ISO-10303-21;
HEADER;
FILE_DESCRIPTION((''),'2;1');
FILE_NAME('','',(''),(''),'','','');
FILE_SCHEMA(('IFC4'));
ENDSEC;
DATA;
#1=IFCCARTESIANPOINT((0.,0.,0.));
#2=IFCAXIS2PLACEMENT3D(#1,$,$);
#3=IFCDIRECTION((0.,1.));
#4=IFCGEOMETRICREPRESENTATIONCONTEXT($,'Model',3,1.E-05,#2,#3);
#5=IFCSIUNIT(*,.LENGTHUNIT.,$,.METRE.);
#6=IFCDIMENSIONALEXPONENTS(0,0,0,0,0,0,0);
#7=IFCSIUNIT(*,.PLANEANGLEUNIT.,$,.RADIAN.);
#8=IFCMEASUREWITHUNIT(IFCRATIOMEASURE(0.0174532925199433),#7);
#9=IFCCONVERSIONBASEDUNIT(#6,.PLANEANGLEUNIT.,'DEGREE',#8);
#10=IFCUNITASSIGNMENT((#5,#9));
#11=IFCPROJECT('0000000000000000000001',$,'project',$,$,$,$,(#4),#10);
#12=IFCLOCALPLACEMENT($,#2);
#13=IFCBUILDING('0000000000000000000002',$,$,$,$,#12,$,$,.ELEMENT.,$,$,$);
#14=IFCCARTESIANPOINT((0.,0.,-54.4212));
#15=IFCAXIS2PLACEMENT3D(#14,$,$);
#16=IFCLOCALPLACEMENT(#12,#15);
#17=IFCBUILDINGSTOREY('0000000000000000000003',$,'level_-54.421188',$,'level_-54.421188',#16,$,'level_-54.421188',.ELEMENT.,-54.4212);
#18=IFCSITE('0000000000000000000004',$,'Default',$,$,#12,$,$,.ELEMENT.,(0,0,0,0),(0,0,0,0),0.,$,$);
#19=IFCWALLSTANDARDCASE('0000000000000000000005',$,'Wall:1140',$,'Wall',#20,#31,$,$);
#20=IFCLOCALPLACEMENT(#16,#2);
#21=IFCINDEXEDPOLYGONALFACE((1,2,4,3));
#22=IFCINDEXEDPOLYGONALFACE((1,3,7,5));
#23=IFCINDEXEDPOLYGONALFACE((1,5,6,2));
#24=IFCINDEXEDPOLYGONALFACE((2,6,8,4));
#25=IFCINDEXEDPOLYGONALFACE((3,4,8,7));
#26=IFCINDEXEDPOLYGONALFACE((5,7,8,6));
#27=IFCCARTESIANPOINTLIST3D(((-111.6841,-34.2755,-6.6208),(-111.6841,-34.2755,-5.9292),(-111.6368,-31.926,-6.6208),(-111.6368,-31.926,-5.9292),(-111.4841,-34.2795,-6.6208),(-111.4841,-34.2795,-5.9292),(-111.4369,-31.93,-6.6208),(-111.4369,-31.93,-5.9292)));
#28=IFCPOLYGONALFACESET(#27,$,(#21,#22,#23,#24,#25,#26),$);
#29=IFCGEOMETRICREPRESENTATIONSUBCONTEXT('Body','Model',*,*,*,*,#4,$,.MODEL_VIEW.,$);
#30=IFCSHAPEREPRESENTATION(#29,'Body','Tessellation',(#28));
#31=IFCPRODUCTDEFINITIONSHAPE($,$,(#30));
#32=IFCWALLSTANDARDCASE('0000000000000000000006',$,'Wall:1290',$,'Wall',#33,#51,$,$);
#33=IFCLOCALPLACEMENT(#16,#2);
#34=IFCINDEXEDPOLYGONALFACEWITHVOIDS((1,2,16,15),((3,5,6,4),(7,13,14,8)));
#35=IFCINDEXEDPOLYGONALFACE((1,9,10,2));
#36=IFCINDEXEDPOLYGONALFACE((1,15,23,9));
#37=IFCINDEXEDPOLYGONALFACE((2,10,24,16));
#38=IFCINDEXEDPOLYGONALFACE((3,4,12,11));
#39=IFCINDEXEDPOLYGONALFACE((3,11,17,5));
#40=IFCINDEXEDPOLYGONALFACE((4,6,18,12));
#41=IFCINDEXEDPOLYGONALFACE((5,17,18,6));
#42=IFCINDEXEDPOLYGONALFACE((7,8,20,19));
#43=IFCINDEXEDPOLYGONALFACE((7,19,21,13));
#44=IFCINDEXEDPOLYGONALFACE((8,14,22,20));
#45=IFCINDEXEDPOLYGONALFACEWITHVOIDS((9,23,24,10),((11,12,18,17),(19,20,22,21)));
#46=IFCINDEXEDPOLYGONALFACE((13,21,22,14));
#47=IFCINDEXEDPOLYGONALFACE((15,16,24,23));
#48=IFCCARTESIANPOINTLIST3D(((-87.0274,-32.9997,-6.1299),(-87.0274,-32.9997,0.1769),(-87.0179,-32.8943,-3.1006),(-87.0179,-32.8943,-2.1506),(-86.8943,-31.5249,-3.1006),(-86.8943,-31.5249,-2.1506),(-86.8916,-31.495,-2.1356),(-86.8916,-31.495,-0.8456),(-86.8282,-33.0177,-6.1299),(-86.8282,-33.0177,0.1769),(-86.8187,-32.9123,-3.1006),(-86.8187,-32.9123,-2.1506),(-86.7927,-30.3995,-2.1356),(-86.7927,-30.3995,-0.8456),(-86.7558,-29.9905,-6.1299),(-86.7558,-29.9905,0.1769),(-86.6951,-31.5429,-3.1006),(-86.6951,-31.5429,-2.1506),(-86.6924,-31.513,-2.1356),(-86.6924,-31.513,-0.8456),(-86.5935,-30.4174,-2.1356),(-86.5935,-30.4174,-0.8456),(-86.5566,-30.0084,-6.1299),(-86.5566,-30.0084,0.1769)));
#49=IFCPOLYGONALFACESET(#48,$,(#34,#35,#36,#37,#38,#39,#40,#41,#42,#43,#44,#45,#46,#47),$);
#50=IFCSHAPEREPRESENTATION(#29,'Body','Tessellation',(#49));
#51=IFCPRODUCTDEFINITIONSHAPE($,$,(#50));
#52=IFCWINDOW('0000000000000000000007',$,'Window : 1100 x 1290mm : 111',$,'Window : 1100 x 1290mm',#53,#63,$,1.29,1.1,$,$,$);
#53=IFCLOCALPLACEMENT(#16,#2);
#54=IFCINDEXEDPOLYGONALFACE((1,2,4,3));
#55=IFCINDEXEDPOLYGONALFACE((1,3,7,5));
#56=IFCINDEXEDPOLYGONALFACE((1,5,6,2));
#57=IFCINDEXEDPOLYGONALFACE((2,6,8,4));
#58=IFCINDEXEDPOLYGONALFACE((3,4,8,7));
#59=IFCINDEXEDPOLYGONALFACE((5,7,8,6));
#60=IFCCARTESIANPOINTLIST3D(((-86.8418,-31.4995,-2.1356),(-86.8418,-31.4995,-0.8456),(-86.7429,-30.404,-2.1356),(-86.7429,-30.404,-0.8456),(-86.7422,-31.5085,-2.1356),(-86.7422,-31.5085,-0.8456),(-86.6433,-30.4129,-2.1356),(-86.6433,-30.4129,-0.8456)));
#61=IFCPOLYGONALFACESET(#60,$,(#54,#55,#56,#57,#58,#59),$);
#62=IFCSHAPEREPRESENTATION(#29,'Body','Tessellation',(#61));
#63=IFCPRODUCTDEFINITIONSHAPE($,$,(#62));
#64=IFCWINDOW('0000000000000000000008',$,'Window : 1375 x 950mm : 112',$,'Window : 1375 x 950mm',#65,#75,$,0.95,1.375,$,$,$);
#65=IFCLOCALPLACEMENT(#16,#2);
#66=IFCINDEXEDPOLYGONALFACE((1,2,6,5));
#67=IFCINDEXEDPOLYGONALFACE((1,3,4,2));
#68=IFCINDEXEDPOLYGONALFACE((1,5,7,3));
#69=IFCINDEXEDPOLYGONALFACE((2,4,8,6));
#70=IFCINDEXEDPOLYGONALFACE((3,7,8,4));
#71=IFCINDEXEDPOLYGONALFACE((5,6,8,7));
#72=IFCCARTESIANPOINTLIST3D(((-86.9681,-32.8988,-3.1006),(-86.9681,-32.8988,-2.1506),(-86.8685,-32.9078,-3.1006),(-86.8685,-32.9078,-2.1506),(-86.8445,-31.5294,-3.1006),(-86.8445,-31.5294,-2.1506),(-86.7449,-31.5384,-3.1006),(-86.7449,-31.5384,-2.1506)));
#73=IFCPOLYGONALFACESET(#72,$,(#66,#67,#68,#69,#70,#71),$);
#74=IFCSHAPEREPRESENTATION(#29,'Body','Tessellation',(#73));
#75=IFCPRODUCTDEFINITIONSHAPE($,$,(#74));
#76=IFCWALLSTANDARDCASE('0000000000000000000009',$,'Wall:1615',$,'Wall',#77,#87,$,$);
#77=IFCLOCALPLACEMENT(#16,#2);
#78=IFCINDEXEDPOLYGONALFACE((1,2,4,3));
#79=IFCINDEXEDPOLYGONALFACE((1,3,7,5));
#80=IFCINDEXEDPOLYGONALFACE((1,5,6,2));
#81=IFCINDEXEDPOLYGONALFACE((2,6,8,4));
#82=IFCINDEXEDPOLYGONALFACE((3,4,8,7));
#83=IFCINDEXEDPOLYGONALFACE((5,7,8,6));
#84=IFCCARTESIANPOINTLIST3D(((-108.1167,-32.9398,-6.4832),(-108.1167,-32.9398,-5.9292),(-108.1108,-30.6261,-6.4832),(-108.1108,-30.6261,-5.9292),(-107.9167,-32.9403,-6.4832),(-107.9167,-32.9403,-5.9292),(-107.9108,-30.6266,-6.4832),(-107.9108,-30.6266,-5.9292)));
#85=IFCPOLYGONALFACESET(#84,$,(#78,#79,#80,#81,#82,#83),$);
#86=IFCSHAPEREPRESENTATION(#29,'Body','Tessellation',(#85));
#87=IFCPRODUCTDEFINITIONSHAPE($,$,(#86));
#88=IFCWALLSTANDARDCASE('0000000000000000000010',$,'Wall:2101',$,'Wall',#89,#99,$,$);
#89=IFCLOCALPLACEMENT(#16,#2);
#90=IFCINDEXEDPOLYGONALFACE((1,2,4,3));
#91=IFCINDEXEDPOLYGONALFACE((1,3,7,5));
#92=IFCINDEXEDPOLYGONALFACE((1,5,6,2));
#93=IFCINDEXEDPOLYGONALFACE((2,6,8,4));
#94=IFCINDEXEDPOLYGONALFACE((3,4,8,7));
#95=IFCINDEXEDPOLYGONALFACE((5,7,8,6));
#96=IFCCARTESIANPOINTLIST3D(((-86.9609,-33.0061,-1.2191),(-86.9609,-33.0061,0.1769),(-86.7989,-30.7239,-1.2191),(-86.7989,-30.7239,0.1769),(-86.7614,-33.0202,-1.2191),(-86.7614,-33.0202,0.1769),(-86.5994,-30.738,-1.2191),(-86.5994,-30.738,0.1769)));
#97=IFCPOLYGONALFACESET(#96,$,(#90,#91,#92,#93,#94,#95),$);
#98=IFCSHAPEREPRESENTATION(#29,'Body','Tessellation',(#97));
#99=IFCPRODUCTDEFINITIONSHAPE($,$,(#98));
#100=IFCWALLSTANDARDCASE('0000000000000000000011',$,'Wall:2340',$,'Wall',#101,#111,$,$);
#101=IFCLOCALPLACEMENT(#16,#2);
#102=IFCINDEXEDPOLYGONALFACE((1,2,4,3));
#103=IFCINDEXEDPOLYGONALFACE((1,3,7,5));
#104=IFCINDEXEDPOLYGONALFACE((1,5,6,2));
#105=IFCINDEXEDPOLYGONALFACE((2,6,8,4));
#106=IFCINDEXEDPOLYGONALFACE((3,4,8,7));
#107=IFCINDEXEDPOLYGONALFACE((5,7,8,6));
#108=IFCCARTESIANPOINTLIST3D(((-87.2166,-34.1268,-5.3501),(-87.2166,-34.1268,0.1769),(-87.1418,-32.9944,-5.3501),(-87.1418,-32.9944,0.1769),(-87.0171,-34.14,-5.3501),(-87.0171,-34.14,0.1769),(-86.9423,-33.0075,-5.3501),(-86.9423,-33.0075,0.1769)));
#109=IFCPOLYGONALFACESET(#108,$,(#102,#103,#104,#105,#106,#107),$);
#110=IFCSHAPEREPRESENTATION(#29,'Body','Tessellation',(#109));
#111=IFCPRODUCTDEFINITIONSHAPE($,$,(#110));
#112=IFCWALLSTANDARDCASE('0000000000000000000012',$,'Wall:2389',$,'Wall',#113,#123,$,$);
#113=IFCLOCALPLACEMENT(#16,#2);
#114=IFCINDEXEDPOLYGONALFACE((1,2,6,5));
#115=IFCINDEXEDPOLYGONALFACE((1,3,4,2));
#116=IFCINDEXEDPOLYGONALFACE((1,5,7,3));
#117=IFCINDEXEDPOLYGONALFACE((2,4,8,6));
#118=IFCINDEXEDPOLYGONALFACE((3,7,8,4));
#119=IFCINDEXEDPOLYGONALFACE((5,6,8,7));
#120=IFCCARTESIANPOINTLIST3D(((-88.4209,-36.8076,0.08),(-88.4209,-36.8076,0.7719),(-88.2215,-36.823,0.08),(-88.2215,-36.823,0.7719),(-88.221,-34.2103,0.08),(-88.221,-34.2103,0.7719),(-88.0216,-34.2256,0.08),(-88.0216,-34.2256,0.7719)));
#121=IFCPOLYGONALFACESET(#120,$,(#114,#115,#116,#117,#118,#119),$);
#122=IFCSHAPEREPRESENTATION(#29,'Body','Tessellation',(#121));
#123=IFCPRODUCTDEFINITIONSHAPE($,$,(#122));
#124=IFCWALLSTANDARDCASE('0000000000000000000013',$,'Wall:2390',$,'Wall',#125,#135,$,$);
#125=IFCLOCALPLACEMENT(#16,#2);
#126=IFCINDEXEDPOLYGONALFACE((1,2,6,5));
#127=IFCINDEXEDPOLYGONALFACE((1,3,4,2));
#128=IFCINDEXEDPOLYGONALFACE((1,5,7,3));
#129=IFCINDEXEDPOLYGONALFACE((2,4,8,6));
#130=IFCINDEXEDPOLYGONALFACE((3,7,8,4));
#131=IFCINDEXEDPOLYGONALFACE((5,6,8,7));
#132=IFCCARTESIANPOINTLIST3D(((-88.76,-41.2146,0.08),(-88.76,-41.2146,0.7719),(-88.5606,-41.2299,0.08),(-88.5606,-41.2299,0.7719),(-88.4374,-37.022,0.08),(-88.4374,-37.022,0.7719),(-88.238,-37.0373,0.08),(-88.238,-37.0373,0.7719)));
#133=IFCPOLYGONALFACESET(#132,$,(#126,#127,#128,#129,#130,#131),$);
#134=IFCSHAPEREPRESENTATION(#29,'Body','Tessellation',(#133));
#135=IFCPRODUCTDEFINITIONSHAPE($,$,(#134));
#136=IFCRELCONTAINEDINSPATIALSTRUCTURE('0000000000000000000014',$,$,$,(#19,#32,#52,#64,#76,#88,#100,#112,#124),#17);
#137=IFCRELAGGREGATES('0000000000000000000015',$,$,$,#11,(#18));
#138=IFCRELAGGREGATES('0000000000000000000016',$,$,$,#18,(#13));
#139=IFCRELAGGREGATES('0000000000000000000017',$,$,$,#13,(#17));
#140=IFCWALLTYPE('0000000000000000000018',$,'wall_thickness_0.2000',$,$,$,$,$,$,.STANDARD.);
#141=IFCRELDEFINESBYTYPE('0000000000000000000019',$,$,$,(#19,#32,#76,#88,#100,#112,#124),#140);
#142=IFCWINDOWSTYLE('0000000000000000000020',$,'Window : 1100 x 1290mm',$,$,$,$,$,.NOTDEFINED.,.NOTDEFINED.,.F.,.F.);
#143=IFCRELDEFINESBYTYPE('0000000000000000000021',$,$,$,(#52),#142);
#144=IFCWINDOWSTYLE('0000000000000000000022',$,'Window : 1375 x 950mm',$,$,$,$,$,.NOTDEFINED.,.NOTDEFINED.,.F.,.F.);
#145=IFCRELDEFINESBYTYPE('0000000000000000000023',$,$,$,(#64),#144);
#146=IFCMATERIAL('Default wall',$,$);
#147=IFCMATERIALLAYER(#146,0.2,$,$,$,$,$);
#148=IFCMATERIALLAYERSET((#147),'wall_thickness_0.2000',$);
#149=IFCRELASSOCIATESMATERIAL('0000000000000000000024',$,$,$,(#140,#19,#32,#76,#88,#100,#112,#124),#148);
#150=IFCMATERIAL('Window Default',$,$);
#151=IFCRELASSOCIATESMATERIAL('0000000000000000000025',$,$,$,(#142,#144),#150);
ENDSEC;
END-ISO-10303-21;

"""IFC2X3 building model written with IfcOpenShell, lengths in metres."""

from ifc_helpers import new_model, entity, si_unit, converted_unit, direction, frame, frame_2d, origin, origin_2d_with_axis, place, context, subcontext, project, spatial, polyline, rectangle, outline, extrude, source, transform, mapped, material, layer, layer_set, layer_usage, type_object, type_shapes, element, fill, save


model = new_model("IFC2X3")

# Units and contexts
model_context = context("Model", 3, precision=1e-05, world=origin(), true_north=direction((0.0, 1.0)))
body_context = subcontext(model_context, "Body", "Model", "MODEL_VIEW")
ifc_project = project(units=[si_unit("LENGTHUNIT", "METRE"), converted_unit("PLANEANGLEUNIT", "DEGREE", entity("IfcRatioMeasure", 0.0174532925199433), si_unit("PLANEANGLEUNIT", "RADIAN"), dimensions=[0, 0, 0, 0, 0, 0, 0])], contexts=[model_context])

# Site, building, storey
placement_1 = place(None, origin())
site = spatial("IfcSite", under=ifc_project, at=placement_1, Name="Default", CompositionType="ELEMENT", RefLatitude=(0, 0, 0, 0), RefLongitude=(0, 0, 0, 0), RefElevation=0.0)
building = spatial("IfcBuilding", under=site, at=placement_1, CompositionType="ELEMENT")
storey_placement = place(placement_1, frame((0.0, 0.0, -54.4212)))
storey = spatial("IfcBuildingStorey", under=building, at=storey_placement, Name="level_-54.421188", ObjectType="level_-54.421188", LongName="level_-54.421188", CompositionType="ELEMENT", Elevation=-54.4212)

# Shared definitions
ifc_material_1 = material(Name="Default wall")
ifc_layer = layer(ifc_material_1, 0.2)
ifc_layer_set = layer_set([ifc_layer], Name="wall_thickness_0.2000")
ifc_layer_usage = layer_usage(ifc_layer_set, "AXIS2", "POSITIVE", -0.1)
wall_type = type_object("IfcWallType", Name="wall_thickness_0.2000", PredefinedType="STANDARD", material=ifc_layer_set)

# Shared definitions
ifc_material_2 = material(Name="Window Default")

# Wall
placement_2 = place(placement_1, frame((0.0, 0.0, -61.042)))
wall_1_placement = place(placement_2, frame((-111.5369, -31.928, 0.0), z_axis=(0.0, 0.0, 1.0), x_axis=(-0.020093, -0.999798, 0.0)))
element("IfcWallStandardCase", 1, at=wall_1_placement, inside=storey, type_object=wall_type, material=ifc_layer_usage, Name="Wall:1140", ObjectType="Wall", context=body_context, shape_type="SweptSolid", body=[
    extrude(outline(polyline([(2.35, -0.1), (2.35, 0.1), (0.0, 0.1), (0.0, -0.1), (2.35, -0.1)])), origin(), (0.0, 0.0, 1.0), 0.6917),
])

# Wall, openings, windows
placement_3 = place(placement_1, frame((0.0, 0.0, -60.5511)))
wall_2_placement = place(placement_3, frame((-86.9278, -33.0087, 0.0), z_axis=(0.0, 0.0, 1.0), x_axis=(0.089888, 0.995952, 0.0)))
wall_2 = element("IfcWallStandardCase", 2, at=wall_2_placement, inside=storey, type_object=wall_type, material=ifc_layer_usage, Name="Wall:1290", ObjectType="Wall", context=body_context, shape_type="SweptSolid", body=[
    extrude(outline(polyline([(3.0214, -0.1), (3.0214, 0.1), (0.0, 0.1), (0.0, -0.1), (3.0214, -0.1)])), origin(), (0.0, 0.0, 1.0), 6.3068),
])
opening_1_placement = place(wall_2_placement, frame((1.5108, -0.1, 3.9943)))
opening_1 = element("IfcOpeningElement", 3, at=opening_1_placement, cuts=wall_2, ObjectType="Opening", context=body_context, shape_type="SweptSolid", body=[
    extrude(rectangle(XDim=1.1, YDim=1.29, at=frame_2d((0.645, 0.55), x_axis=(0.0, 1.0))), frame((0.0, 0.0, 0.0), z_axis=(0.0, 1.0, 0.0), x_axis=(0.0, 0.0, 1.0)), (0.0, 0.0, 1.0), 0.2),
])
opening_2_placement = place(wall_2_placement, frame((0.1058, -0.1, 3.0293)))
opening_2 = element("IfcOpeningElement", 4, at=opening_2_placement, cuts=wall_2, ObjectType="Opening", context=body_context, shape_type="SweptSolid", body=[
    extrude(rectangle(XDim=1.375, YDim=0.95, at=frame_2d((0.475, 0.6875), x_axis=(0.0, 1.0))), frame((0.0, 0.0, 0.0), z_axis=(0.0, 1.0, 0.0), x_axis=(0.0, 0.0, 1.0)), (0.0, 0.0, 1.0), 0.2),
])
window_style_1 = type_object("IfcWindowStyle", Name="Window : 1100 x 1290mm", ConstructionType="NOTDEFINED", OperationType="NOTDEFINED", ParameterTakesPrecedence=False, Sizeable=False, material=ifc_material_2)
shared_shape_1 = source(origin(), body_context, "Body", "SweptSolid", [
    extrude(rectangle(XDim=0.1, YDim=1.1, at=origin_2d_with_axis()), frame((0.55, 0.1, 0.0), z_axis=(0.0, 0.0, 1.0), x_axis=(0.0, 1.0, 0.0)), (0.0, 0.0, 1.0), 1.29),
])
type_shapes(window_style_1, [shared_shape_1])
window_1_placement = place(opening_1_placement, origin())
window_1 = element("IfcWindow", 5, at=window_1_placement, inside=storey, type_object=window_style_1, Name="Window : 1100 x 1290mm : 111", ObjectType="Window : 1100 x 1290mm", OverallHeight=1.29, OverallWidth=1.1, context=body_context, shape_type="MappedRepresentation", body=[
    mapped(shared_shape_1, transform((0.0, 0.0, 0.0), scale=1.0)),
])
fill(opening_1, window_1)
window_style_2 = type_object("IfcWindowStyle", Name="Window : 1375 x 950mm", ConstructionType="NOTDEFINED", OperationType="NOTDEFINED", ParameterTakesPrecedence=False, Sizeable=False, material=ifc_material_2)
shared_shape_2 = source(origin(), body_context, "Body", "SweptSolid", [
    extrude(rectangle(XDim=0.1, YDim=1.375, at=origin_2d_with_axis()), frame((0.6875, 0.1, 0.0), z_axis=(0.0, 0.0, 1.0), x_axis=(0.0, 1.0, 0.0)), (0.0, 0.0, 1.0), 0.95),
])
type_shapes(window_style_2, [shared_shape_2])
window_2_placement = place(opening_2_placement, origin())
window_2 = element("IfcWindow", 6, at=window_2_placement, inside=storey, type_object=window_style_2, Name="Window : 1375 x 950mm : 112", ObjectType="Window : 1375 x 950mm", OverallHeight=0.95, OverallWidth=1.375, context=body_context, shape_type="MappedRepresentation", body=[
    mapped(shared_shape_2, transform((0.0, 0.0, 0.0), scale=1.0)),
])
fill(opening_2, window_2)

# Walls
placement_4 = place(placement_1, frame((0.0, 0.0, -60.9044)))
wall_3_placement = place(placement_4, frame((-108.0167, -32.94, 0.0), z_axis=(0.0, 0.0, 1.0), x_axis=(0.002552, 0.999997, 0.0)))
element("IfcWallStandardCase", 7, at=wall_3_placement, inside=storey, type_object=wall_type, material=ifc_layer_usage, Name="Wall:1615", ObjectType="Wall", context=body_context, shape_type="SweptSolid", body=[
    extrude(outline(polyline([(2.3137, -0.1), (2.3137, 0.1), (0.0, 0.1), (0.0, -0.1), (2.3137, -0.1)])), origin(), (0.0, 0.0, 1.0), 0.554),
])
placement_5 = place(placement_1, frame((0.0, 0.0, -55.6403)))
wall_4_placement = place(placement_5, frame((-86.8611, -33.0132, 0.0), z_axis=(0.0, 0.0, 1.0), x_axis=(0.070786, 0.997491, 0.0)))
element("IfcWallStandardCase", 8, at=wall_4_placement, inside=storey, type_object=wall_type, material=ifc_layer_usage, Name="Wall:2101", ObjectType="Wall", context=body_context, shape_type="SweptSolid", body=[
    extrude(outline(polyline([(2.288, -0.1), (2.288, 0.1), (0.0, 0.1), (0.0, -0.1), (2.288, -0.1)])), origin(), (0.0, 0.0, 1.0), 1.396),
])
placement_6 = place(placement_1, frame((0.0, 0.0, -59.7713)))
wall_5_placement = place(placement_6, frame((-87.1169, -34.1334, 0.0), z_axis=(0.0, 0.0, 1.0), x_axis=(0.065912, 0.997825, 0.0)))
element("IfcWallStandardCase", 9, at=wall_5_placement, inside=storey, type_object=wall_type, material=ifc_layer_usage, Name="Wall:2340", ObjectType="Wall", context=body_context, shape_type="SweptSolid", body=[
    extrude(outline(polyline([(1.1349, -0.1), (1.1349, 0.1), (0.0, 0.1), (0.0, -0.1), (1.1349, -0.1)])), origin(), (0.0, 0.0, 1.0), 5.527),
])
placement_7 = place(placement_1, frame((0.0, 0.0, -54.3412)))
wall_6_placement = place(placement_7, frame((-88.3212, -36.8153, 0.0), z_axis=(0.0, 0.0, 1.0), x_axis=(0.076724, 0.997052, 0.0)))
element("IfcWallStandardCase", 10, at=wall_6_placement, inside=storey, type_object=wall_type, material=ifc_layer_usage, Name="Wall:2389", ObjectType="Wall", context=body_context, shape_type="SweptSolid", body=[
    extrude(outline(polyline([(2.605, -0.1), (2.605, 0.1), (0.0, 0.1), (0.0, -0.1), (2.605, -0.1)])), origin(), (0.0, 0.0, 1.0), 0.692),
])
placement_8 = place(placement_1, frame((0.0, 0.0, -54.3412)))
wall_7_placement = place(placement_8, frame((-88.6603, -41.2223, 0.0), z_axis=(0.0, 0.0, 1.0), x_axis=(0.076726, 0.997052, 0.0)))
element("IfcWallStandardCase", 11, at=wall_7_placement, inside=storey, type_object=wall_type, material=ifc_layer_usage, Name="Wall:2390", ObjectType="Wall", context=body_context, shape_type="SweptSolid", body=[
    extrude(outline(polyline([(4.205, -0.1), (4.205, 0.1), (0.0, 0.1), (0.0, -0.1), (4.205, -0.1)])), origin(), (0.0, 0.0, 1.0), 0.692),
])

save(model, "model.ifc")
